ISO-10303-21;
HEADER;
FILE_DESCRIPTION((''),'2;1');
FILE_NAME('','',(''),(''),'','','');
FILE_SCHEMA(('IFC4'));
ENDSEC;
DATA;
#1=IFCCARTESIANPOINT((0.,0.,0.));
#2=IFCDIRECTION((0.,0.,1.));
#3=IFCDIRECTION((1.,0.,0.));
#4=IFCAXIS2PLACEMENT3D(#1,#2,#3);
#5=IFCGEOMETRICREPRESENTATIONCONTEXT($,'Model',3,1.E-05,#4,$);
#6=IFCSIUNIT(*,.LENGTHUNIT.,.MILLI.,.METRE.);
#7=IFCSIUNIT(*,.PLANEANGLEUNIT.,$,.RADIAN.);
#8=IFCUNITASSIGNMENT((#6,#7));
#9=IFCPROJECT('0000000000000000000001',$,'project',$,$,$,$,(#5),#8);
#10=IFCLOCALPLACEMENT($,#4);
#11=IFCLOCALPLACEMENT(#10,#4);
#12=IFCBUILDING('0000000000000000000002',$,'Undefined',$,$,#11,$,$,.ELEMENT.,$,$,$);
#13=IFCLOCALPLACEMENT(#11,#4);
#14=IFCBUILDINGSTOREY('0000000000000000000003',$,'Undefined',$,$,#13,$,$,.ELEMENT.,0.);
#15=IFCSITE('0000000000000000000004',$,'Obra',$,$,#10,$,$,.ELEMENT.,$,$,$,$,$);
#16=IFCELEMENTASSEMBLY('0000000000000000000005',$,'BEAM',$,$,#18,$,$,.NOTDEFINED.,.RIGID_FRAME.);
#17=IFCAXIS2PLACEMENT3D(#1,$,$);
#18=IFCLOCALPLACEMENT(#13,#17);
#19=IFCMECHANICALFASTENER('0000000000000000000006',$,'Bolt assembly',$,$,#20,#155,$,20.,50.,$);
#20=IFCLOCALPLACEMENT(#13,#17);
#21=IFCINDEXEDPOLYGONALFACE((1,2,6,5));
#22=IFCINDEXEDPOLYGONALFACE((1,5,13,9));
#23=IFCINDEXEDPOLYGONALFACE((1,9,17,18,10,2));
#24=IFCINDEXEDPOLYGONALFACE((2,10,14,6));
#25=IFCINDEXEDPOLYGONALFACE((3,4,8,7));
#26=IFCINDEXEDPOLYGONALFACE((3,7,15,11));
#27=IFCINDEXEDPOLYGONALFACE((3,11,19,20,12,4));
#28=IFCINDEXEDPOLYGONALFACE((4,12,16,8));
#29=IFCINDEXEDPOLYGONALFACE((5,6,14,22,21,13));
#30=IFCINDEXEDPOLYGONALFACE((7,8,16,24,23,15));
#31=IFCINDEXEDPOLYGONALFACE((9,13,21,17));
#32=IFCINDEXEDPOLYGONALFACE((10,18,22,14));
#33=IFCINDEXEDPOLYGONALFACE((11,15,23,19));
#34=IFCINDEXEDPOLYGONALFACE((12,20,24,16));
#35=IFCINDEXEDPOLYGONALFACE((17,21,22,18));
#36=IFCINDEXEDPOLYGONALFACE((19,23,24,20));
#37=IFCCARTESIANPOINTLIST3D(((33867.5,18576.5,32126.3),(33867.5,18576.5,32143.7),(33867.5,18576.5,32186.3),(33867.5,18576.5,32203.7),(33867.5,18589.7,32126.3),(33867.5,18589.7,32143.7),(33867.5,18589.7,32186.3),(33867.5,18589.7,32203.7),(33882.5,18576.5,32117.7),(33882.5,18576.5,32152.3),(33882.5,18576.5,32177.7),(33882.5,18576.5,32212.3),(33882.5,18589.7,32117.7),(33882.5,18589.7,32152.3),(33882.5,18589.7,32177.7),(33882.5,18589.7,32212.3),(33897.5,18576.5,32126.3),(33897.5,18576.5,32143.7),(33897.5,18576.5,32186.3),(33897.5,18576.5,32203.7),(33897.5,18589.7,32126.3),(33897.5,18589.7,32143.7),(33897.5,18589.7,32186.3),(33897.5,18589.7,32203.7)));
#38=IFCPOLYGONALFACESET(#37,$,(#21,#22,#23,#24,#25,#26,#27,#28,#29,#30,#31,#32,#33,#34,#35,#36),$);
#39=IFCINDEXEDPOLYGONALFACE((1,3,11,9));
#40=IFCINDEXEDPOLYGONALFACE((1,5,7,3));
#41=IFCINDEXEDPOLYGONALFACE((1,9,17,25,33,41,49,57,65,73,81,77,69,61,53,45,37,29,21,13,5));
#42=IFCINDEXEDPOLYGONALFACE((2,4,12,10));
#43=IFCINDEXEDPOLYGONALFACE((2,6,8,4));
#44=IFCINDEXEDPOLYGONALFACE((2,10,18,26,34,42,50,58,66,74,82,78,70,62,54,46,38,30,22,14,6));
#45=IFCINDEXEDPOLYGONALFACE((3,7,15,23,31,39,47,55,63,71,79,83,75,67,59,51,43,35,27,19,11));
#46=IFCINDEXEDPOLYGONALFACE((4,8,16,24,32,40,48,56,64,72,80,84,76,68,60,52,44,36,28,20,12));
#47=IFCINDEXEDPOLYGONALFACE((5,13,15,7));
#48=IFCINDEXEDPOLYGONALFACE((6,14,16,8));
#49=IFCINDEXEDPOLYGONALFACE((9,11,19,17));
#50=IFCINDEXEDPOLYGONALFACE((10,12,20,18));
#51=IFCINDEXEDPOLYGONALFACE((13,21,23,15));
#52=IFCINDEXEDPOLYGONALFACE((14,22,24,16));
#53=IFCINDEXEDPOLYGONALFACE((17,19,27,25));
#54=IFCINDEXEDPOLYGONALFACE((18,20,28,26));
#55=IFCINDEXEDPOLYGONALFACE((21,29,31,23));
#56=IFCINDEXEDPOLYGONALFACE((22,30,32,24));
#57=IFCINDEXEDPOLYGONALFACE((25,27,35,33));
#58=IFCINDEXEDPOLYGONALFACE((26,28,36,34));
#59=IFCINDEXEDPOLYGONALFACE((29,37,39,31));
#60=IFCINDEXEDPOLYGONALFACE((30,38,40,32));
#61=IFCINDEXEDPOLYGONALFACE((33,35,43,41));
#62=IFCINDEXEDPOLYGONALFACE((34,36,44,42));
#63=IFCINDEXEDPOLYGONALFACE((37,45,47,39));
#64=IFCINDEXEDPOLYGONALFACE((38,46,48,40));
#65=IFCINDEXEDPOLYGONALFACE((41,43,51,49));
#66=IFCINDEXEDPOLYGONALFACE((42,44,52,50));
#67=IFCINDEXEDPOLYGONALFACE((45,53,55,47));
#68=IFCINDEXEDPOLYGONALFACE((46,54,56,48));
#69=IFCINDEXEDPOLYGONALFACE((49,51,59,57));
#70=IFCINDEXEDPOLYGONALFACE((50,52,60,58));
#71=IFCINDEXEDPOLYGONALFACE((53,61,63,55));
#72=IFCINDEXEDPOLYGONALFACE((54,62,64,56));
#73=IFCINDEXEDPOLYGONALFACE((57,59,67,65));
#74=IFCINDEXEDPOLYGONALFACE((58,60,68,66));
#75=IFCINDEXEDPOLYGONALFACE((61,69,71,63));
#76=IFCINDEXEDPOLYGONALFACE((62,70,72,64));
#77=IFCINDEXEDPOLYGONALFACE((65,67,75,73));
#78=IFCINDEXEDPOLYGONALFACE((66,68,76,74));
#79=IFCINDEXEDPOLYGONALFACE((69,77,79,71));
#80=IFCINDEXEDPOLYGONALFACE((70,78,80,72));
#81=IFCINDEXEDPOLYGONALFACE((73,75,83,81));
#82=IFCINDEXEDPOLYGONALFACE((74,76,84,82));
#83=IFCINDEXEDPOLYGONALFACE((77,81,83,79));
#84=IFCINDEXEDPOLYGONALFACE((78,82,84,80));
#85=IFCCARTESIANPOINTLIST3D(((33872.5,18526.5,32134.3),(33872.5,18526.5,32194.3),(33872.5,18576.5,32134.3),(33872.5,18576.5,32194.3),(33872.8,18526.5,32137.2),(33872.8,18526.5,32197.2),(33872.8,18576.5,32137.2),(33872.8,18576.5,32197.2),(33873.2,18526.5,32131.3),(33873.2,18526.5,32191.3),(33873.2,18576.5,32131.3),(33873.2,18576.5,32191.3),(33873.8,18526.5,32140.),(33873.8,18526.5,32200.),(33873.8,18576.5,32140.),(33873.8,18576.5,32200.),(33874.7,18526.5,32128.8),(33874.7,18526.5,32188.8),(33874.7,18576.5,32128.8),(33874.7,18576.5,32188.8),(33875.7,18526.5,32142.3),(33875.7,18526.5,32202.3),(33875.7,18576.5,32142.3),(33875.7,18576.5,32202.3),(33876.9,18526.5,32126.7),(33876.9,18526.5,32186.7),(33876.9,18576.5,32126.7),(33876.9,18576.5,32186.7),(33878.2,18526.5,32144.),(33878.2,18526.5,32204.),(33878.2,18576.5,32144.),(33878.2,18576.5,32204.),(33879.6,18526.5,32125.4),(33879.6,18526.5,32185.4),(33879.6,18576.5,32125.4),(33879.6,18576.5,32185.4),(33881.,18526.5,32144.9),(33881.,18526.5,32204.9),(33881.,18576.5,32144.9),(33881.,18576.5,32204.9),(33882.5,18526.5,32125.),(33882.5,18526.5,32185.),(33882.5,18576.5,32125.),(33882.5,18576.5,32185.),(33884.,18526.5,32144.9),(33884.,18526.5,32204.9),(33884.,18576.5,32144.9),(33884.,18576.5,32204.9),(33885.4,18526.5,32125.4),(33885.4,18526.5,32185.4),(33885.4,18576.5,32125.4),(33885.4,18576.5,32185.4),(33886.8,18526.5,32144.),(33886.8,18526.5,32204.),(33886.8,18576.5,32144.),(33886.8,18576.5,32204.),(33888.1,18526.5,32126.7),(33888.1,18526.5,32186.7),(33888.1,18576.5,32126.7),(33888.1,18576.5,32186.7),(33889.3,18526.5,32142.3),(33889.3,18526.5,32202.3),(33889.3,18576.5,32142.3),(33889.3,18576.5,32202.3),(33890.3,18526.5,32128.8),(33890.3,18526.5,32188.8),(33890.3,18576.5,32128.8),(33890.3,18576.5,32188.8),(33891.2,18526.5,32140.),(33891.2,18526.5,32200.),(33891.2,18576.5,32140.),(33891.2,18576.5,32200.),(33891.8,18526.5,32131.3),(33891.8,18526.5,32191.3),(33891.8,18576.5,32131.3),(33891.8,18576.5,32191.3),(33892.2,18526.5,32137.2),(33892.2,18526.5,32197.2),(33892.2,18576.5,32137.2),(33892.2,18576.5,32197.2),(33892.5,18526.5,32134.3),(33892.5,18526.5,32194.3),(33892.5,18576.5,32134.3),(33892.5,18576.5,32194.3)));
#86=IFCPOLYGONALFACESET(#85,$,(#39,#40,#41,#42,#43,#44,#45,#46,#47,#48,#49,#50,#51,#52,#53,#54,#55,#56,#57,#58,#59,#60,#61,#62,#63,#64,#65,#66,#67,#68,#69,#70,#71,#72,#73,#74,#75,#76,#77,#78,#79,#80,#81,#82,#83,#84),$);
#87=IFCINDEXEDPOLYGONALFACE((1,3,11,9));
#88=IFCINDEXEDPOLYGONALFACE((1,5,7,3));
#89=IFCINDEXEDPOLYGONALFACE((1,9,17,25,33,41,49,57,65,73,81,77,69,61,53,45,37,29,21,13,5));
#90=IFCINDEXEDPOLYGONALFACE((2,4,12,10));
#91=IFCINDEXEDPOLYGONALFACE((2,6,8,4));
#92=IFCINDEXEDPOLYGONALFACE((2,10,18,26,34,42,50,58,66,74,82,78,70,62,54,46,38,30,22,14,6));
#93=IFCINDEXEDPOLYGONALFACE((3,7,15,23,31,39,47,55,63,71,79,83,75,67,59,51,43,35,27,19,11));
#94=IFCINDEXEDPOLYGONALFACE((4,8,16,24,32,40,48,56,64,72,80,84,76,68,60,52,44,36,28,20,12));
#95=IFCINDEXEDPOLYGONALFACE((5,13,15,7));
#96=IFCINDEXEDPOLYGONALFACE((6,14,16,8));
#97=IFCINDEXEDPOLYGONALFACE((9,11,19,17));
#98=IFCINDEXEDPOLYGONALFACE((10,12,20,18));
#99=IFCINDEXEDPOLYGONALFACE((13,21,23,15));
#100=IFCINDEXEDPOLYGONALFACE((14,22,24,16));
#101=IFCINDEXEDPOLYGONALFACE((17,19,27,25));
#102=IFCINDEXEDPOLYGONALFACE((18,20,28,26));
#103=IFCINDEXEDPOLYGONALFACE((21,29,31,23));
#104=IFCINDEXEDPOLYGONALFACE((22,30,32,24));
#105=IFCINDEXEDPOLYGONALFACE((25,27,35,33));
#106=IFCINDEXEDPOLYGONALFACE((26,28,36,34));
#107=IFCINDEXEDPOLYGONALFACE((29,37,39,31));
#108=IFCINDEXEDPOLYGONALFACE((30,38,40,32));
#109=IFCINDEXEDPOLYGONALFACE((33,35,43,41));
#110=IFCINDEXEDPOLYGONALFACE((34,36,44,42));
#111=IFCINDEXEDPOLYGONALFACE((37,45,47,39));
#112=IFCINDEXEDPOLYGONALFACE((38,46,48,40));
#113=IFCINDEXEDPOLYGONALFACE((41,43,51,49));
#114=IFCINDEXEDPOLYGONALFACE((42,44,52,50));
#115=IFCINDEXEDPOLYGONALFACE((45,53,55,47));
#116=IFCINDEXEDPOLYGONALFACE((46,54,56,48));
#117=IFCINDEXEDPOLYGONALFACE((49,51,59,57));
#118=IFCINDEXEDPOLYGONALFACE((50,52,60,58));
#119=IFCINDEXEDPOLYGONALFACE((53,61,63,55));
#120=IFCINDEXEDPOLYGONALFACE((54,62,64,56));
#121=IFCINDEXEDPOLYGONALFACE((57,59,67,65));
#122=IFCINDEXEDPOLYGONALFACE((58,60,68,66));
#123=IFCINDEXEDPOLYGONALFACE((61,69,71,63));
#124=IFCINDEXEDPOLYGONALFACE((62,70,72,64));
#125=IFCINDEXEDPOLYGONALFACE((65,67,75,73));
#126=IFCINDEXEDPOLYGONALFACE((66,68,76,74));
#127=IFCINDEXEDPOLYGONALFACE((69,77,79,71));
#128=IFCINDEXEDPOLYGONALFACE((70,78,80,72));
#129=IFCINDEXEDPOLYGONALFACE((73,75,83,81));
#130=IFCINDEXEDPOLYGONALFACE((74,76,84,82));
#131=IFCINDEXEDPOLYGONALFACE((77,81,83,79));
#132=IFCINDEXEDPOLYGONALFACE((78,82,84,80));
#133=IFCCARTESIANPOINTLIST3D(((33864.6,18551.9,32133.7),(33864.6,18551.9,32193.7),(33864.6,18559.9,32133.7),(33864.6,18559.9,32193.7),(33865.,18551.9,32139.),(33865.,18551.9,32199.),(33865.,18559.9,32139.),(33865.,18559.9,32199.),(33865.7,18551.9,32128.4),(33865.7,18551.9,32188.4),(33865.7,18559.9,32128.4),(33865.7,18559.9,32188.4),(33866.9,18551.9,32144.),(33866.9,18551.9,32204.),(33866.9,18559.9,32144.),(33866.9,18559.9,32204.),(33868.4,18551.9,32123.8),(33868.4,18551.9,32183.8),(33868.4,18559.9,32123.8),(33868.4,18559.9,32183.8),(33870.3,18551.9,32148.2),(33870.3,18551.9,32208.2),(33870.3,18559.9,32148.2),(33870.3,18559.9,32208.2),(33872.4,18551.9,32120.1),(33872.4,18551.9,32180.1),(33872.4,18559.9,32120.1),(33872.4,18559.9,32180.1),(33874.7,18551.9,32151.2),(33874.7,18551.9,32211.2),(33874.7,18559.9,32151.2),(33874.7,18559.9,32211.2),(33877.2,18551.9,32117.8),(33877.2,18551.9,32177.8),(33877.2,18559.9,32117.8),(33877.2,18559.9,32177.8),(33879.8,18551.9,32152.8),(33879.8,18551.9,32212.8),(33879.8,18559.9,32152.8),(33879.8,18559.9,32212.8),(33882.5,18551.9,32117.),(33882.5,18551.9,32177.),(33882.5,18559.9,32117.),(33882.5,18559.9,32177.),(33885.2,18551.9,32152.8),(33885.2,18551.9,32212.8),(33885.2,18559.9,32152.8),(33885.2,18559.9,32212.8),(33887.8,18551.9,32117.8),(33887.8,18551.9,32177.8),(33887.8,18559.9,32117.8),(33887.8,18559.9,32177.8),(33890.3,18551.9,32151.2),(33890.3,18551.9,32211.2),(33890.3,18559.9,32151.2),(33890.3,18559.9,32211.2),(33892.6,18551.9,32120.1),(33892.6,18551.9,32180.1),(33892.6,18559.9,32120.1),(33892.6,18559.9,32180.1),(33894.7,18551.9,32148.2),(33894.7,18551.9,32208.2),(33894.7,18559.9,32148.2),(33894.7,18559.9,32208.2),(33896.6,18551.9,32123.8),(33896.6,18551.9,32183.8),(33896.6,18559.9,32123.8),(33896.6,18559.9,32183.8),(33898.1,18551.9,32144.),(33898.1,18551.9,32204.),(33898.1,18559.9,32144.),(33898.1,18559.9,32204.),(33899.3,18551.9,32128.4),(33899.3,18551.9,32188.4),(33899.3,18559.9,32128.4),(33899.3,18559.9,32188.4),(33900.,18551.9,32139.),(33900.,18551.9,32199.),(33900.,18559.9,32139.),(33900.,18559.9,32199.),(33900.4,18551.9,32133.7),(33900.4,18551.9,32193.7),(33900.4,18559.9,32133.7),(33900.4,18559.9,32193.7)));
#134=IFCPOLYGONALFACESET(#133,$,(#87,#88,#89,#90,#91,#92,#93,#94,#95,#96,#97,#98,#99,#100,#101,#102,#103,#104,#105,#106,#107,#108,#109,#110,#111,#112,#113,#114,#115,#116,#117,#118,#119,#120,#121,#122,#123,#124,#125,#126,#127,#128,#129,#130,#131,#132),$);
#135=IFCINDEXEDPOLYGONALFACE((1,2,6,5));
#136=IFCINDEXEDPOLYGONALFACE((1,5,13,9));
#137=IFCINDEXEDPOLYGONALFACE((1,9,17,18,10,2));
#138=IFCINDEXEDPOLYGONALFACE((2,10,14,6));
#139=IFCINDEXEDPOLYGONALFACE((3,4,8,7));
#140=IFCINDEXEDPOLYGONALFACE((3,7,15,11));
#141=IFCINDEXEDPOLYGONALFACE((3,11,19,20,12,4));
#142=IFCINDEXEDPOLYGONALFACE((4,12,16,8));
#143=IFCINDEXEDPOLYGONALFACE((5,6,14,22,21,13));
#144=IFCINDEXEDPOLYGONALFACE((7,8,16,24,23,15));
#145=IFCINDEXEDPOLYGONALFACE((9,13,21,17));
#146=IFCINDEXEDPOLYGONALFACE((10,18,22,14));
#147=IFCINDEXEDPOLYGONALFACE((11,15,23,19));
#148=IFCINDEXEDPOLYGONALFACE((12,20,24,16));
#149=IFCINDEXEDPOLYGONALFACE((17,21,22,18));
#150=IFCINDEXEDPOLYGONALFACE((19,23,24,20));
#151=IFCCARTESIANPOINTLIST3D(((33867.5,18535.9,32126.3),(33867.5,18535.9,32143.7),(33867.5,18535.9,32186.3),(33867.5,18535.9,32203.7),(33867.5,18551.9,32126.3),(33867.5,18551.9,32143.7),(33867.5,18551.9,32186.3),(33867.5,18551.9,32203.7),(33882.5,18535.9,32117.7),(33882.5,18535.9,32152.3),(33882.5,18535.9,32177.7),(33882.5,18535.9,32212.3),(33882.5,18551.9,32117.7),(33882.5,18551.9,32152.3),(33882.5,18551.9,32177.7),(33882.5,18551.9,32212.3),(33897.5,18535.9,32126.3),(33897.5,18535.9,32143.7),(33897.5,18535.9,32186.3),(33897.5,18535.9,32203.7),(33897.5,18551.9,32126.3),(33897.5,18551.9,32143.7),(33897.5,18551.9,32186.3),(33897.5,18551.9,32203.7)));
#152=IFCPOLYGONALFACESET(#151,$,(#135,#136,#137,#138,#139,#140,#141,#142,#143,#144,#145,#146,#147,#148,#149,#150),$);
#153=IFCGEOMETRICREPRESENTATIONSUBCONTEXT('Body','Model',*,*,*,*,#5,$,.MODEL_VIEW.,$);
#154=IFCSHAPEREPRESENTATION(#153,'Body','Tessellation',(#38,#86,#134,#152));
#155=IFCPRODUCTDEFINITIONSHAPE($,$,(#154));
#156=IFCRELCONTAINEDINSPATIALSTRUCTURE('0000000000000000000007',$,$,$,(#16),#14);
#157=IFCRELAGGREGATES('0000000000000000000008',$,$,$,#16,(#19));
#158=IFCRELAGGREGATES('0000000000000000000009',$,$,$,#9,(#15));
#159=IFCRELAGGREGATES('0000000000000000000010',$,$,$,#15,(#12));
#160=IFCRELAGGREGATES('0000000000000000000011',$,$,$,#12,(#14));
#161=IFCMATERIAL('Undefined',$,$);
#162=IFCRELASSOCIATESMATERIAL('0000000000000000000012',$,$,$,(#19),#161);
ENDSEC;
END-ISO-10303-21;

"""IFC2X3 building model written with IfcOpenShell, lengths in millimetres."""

from ifc_helpers import new_model, si_unit, frame, origin_with_axes, origin_2d_with_axis, place, context, subcontext, project, spatial, polyline, circle, outline, extrude, source, transform, mapped, material, element, aggregate, save


model = new_model("IFC2X3")

# Units and contexts
model_context = context("Model", 3, precision=1e-05, world=origin_with_axes())
body_context = subcontext(model_context, "Body", "Model", "MODEL_VIEW")
ifc_project = project(units=[si_unit("LENGTHUNIT", "METRE", prefix="MILLI"), si_unit("PLANEANGLEUNIT", "RADIAN")], contexts=[model_context])

# Site, building, storey
site_placement = place(None, origin_with_axes())
site = spatial("IfcSite", under=ifc_project, at=site_placement, Name="Obra", CompositionType="ELEMENT")
building_placement = place(site_placement, origin_with_axes())
building = spatial("IfcBuilding", under=site, at=building_placement, Name="Undefined", CompositionType="ELEMENT")
storey_placement = place(building_placement, origin_with_axes())
storey = spatial("IfcBuildingStorey", under=building, at=storey_placement, Name="Undefined", CompositionType="ELEMENT", Elevation=0.0)

# Shared definitions
ifc_material_1 = material(Name="Undefined")
shared_shape_1 = source(origin_with_axes(), body_context, "Body", "SweptSolid", [
    extrude(outline(polyline([(17.3, 0.0), (8.7, 15.0), (-8.7, 15.0), (-17.3, 0.0), (-8.7, -15.0), (8.7, -15.0), (17.3, 0.0)])), frame((0.0, -26.5, 0.0), z_axis=(0.0, 1.0, 0.0), x_axis=(1.0, 0.0, 0.0)), (0.0, 0.0, 1.0), 13.2),
    extrude(circle(Radius=10.0, at=origin_2d_with_axis()), frame((0.0, -13.3, 0.0), z_axis=(0.0, 1.0, 0.0), x_axis=(1.0, 0.0, 0.0)), (0.0, 0.0, 1.0), 50.0),
    extrude(circle(Radius=18.0, at=origin_2d_with_axis()), frame((0.0, 3.3, 0.0), z_axis=(0.0, 1.0, 0.0), x_axis=(1.0, 0.0, 0.0)), (0.0, 0.0, 1.0), 8.0),
    extrude(outline(polyline([(17.3, 0.0), (8.7, 15.0), (-8.7, 15.0), (-17.3, 0.0), (-8.7, -15.0), (8.7, -15.0), (17.3, 0.0)])), frame((0.0, 11.3, 0.0), z_axis=(0.0, 1.0, 0.0), x_axis=(1.0, 0.0, 0.0)), (0.0, 0.0, 1.0), 16.0),
])

# Element assembly, mechanical fastener
assembly_1_placement = place(storey_placement, origin_with_axes())
assembly_1 = element("IfcElementAssembly", 1, at=assembly_1_placement, inside=storey, Name="BEAM", AssemblyPlace="NOTDEFINED", PredefinedType="RIGID_FRAME")
mechanical_fastener_1_placement = place(assembly_1_placement, frame((33922.5, 18563.2, 32235.0), z_axis=(-1.0, 0.0, 0.0), x_axis=(0.0, 0.0, -1.0)))
mechanical_fastener_1 = element("IfcMechanicalFastener", 2, at=mechanical_fastener_1_placement, material=ifc_material_1, Name="Bolt assembly", NominalDiameter=20.0, NominalLength=50.0, context=body_context, shape_type="MappedRepresentation", body=[
    mapped(shared_shape_1, transform((40.0, 0.0, 40.0))),
    mapped(shared_shape_1, transform((100.0, 0.0, 40.0))),
])

aggregate(assembly_1, [mechanical_fastener_1])

save(model, "model.ifc")
